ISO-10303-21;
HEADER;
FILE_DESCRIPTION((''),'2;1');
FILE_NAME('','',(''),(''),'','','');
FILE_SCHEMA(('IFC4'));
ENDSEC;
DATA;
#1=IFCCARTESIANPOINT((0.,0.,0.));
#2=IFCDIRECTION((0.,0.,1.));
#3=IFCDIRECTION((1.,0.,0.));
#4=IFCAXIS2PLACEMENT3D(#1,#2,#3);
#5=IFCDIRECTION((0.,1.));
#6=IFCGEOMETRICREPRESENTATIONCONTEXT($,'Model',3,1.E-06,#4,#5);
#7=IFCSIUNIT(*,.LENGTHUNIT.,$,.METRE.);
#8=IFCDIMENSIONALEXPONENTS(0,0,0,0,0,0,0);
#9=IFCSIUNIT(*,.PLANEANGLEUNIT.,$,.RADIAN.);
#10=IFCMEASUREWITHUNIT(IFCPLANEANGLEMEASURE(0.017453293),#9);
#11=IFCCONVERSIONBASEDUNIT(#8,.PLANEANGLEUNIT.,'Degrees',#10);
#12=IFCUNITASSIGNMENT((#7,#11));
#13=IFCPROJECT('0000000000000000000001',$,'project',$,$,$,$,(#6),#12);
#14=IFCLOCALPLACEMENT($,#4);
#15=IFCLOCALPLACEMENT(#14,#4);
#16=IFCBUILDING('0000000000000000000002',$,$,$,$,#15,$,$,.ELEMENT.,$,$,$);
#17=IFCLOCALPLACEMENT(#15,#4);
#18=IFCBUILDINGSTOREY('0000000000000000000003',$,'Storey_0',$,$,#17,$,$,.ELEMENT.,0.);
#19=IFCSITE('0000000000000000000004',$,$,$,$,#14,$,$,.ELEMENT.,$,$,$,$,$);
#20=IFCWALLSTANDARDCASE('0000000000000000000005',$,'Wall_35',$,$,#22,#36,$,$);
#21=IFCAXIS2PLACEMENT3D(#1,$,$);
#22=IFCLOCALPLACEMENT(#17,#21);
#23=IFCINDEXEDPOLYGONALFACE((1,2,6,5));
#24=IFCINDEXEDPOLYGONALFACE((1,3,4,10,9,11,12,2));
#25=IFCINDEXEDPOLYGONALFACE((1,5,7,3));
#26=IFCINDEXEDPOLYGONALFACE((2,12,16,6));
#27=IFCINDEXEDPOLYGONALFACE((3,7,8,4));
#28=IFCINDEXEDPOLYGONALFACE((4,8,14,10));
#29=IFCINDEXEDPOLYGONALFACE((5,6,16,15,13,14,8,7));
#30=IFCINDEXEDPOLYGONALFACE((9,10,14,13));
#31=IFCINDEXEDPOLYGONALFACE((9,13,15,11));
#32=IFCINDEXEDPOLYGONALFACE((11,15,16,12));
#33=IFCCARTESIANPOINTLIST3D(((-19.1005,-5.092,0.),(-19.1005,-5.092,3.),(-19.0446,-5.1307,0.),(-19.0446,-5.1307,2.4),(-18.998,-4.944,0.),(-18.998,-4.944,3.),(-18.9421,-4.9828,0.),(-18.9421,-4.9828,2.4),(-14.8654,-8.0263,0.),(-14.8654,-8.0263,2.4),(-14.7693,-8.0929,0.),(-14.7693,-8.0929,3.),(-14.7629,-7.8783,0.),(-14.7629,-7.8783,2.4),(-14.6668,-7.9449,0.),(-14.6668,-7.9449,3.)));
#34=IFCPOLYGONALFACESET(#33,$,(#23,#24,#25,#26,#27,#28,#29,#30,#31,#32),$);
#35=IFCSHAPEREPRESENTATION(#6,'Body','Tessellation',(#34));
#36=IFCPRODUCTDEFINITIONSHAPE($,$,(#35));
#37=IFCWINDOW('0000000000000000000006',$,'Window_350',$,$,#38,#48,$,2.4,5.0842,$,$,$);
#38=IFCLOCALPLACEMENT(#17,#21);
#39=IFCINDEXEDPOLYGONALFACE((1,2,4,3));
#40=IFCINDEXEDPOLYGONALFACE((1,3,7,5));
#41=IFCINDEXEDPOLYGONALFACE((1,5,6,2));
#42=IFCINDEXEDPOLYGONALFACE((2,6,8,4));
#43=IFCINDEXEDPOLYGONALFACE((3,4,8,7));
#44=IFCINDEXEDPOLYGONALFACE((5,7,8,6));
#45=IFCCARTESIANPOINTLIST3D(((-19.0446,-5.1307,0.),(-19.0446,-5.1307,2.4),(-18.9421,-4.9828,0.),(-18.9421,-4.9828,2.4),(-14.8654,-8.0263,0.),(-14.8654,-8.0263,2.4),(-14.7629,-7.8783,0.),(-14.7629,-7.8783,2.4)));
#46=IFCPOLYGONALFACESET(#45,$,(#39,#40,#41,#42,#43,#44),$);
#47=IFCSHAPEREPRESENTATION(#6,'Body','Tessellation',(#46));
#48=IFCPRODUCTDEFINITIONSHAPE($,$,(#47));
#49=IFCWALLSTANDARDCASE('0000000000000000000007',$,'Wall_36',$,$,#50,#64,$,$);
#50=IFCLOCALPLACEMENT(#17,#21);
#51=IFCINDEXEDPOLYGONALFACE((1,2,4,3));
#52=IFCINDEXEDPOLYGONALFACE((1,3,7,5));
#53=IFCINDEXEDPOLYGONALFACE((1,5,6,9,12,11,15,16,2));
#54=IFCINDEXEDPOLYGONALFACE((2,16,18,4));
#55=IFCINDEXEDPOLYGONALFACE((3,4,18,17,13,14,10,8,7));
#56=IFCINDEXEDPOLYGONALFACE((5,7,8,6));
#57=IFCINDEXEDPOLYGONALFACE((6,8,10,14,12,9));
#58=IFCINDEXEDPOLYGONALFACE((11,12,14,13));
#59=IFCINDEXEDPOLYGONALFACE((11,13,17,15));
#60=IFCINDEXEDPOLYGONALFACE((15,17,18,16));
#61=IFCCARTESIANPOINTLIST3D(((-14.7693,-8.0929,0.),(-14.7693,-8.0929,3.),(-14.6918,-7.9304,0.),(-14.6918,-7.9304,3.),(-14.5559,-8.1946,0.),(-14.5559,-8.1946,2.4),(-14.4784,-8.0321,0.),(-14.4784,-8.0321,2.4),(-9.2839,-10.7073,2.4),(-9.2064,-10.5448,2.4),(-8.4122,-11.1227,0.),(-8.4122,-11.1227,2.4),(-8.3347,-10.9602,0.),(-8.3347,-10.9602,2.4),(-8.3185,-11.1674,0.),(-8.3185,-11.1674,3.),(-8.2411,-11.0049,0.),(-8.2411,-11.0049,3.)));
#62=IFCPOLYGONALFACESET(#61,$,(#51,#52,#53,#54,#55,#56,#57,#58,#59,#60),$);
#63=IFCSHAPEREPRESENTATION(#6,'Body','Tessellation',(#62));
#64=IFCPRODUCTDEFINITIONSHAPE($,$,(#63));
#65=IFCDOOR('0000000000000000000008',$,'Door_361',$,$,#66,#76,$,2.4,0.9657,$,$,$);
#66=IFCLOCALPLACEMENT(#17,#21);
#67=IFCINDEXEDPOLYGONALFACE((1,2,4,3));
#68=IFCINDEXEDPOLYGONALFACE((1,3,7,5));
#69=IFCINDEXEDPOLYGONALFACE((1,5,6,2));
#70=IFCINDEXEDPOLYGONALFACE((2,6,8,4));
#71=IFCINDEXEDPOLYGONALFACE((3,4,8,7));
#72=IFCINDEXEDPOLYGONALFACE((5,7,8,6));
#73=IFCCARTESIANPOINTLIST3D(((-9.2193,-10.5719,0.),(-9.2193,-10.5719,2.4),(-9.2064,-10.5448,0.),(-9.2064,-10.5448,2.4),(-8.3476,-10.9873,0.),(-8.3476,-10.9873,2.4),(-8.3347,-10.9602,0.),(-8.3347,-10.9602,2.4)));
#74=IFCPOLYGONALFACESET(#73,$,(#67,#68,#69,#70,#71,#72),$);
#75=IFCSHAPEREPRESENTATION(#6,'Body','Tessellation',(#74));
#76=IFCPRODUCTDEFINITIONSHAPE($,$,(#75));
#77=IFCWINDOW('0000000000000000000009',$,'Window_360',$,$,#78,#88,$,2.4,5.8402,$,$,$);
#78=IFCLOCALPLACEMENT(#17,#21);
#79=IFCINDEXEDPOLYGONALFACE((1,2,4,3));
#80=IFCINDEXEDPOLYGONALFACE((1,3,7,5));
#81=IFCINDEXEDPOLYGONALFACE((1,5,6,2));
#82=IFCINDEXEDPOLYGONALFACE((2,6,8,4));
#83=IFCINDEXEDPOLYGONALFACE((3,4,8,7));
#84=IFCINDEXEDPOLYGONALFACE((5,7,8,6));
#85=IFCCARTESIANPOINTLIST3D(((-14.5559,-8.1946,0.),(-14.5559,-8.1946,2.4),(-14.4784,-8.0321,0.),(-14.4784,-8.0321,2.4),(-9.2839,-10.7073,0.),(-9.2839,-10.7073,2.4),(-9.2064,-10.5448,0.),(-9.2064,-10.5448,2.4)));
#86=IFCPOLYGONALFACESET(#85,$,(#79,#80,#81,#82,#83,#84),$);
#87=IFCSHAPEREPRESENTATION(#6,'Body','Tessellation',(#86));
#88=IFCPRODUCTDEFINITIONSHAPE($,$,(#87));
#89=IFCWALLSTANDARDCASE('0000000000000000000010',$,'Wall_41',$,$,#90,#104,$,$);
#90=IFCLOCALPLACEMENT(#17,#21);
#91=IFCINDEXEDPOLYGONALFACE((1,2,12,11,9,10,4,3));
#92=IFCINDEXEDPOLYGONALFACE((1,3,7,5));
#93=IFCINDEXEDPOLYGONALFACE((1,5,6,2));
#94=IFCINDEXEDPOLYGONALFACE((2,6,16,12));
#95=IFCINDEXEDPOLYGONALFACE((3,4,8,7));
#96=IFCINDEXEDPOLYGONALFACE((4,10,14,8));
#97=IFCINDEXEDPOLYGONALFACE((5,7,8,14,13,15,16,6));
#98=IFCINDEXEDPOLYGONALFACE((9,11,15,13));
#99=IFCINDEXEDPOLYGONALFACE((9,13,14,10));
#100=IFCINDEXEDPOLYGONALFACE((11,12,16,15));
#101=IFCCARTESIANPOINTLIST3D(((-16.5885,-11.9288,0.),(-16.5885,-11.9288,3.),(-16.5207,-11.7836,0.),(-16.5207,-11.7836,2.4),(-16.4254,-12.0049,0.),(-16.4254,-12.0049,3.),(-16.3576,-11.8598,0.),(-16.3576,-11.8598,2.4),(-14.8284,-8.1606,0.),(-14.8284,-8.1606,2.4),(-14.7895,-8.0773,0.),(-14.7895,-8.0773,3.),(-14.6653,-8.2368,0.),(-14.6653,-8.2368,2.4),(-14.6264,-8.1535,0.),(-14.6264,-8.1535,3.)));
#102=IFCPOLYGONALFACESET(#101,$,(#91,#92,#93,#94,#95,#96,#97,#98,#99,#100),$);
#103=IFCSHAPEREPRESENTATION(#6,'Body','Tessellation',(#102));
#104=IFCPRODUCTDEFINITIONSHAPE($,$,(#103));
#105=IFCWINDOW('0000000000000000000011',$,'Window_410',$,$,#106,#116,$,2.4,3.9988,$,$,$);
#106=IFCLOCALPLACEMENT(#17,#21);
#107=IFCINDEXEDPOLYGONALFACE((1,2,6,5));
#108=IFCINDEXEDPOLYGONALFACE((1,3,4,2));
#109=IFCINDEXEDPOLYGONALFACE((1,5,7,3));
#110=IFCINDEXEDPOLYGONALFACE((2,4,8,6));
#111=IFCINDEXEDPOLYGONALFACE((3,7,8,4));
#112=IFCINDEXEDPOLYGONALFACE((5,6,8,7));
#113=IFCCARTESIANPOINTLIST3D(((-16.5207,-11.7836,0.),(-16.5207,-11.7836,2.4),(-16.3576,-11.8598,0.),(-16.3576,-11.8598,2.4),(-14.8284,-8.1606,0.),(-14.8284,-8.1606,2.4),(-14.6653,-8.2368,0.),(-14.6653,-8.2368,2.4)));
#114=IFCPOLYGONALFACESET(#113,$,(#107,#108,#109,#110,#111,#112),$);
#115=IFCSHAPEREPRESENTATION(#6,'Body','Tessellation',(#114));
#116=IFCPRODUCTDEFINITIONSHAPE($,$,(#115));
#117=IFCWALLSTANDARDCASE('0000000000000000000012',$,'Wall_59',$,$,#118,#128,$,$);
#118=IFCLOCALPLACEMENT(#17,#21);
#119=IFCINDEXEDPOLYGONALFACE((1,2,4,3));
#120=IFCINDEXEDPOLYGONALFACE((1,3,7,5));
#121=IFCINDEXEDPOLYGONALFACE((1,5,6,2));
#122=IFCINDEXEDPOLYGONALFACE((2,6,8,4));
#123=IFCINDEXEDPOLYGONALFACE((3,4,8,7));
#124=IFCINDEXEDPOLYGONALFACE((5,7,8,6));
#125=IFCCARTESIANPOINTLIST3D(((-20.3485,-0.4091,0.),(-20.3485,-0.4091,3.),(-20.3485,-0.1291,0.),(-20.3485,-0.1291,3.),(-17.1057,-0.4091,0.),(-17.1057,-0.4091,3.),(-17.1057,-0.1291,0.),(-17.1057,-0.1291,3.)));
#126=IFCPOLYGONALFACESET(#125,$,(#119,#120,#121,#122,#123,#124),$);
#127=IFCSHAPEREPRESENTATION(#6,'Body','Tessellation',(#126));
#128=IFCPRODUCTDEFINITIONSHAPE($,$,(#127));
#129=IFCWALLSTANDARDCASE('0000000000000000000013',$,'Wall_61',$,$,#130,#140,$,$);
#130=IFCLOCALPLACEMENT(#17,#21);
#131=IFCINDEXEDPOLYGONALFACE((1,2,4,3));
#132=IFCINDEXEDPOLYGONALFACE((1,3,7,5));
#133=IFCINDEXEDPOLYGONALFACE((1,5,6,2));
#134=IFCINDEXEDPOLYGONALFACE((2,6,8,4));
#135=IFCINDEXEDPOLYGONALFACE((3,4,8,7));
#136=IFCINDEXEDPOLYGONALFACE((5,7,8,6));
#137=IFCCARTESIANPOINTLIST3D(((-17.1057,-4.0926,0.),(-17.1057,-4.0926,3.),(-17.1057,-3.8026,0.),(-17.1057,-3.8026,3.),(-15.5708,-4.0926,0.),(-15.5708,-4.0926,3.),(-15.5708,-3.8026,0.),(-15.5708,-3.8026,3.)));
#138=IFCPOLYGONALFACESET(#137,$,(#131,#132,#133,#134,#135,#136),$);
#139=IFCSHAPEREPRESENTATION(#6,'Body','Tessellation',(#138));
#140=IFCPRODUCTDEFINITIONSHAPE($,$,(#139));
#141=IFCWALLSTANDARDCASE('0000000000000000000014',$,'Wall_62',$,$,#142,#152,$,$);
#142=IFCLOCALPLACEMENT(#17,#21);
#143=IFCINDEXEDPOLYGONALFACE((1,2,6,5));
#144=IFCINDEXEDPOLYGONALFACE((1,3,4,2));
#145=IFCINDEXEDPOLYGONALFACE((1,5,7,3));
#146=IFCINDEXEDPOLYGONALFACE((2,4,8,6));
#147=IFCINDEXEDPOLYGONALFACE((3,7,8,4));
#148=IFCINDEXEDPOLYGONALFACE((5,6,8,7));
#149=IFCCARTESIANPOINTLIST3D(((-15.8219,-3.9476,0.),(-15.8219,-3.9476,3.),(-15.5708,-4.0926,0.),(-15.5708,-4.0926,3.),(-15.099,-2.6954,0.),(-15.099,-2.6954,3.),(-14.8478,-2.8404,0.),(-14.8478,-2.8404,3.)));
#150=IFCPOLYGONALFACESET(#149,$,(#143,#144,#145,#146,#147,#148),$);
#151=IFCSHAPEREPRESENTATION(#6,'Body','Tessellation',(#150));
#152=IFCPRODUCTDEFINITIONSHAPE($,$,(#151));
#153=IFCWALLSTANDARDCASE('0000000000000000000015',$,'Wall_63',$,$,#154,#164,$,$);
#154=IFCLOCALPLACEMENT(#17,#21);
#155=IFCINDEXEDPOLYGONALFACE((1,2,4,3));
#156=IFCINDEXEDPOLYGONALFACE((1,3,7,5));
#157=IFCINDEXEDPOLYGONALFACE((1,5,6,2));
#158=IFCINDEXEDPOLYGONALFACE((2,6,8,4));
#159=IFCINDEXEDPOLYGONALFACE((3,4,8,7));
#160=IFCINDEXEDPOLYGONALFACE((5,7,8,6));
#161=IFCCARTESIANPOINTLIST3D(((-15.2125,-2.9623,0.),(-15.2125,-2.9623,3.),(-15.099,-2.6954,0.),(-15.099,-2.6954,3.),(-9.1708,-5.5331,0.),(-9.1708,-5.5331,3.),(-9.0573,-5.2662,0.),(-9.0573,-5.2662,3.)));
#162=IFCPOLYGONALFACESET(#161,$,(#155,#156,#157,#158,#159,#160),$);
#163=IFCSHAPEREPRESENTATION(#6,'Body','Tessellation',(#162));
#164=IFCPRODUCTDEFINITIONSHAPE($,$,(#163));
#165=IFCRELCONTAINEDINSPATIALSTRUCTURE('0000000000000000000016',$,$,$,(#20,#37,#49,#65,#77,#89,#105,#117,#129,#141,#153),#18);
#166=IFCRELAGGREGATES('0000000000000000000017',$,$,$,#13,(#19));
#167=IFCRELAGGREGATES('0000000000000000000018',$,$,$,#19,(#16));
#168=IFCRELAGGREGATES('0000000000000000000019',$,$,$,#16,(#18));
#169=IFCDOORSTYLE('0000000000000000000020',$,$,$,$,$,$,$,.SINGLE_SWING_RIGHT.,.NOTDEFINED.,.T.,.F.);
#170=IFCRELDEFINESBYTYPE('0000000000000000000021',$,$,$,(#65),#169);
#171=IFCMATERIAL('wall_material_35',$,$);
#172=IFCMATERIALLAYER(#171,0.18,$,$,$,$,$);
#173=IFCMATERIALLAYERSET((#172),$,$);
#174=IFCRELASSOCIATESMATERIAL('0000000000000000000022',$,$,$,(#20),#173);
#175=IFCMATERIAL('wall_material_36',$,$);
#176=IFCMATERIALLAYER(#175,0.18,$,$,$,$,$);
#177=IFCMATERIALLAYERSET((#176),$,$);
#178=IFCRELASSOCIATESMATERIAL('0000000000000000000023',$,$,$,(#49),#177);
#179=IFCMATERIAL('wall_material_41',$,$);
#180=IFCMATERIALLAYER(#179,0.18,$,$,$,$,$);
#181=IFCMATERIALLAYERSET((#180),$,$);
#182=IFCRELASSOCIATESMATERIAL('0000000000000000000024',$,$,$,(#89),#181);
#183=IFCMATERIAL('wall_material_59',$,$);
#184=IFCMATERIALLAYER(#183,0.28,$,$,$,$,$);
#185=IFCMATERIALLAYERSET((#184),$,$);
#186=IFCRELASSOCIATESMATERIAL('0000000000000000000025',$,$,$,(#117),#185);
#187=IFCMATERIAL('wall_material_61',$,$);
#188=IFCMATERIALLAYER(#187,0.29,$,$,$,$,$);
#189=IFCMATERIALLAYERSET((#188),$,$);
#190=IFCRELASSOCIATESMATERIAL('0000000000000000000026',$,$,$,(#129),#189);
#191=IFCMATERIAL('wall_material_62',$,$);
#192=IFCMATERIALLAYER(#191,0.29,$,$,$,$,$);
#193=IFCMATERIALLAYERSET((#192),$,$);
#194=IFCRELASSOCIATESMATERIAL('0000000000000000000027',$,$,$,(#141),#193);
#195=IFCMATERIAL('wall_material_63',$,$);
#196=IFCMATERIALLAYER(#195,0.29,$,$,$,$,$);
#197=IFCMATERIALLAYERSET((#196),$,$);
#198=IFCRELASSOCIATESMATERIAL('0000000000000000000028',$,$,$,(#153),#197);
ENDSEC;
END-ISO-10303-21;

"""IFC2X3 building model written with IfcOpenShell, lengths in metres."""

from ifc_helpers import new_model, entity, si_unit, converted_unit, direction, frame, frame_2d, origin_with_axes, place, context, project, spatial, polyline, rectangle, outline, extrude, material, layer, layer_set, layer_usage, type_object, element, fill, save


model = new_model("IFC2X3")

# Units and contexts
model_context = context("Model", 3, precision=1e-06, world=origin_with_axes(), true_north=direction((0.0, 1.0)))
ifc_project = project(units=[si_unit("LENGTHUNIT", "METRE"), converted_unit("PLANEANGLEUNIT", "Degrees", entity("IfcPlaneAngleMeasure", 0.017453293), si_unit("PLANEANGLEUNIT", "RADIAN"), dimensions=[0, 0, 0, 0, 0, 0, 0])], contexts=[model_context])

# Site, building, storey
site_placement = place(None, origin_with_axes())
site = spatial("IfcSite", under=ifc_project, at=site_placement, CompositionType="ELEMENT")
building_placement = place(site_placement, origin_with_axes())
building = spatial("IfcBuilding", under=site, at=building_placement, CompositionType="ELEMENT")
storey_placement = place(building_placement, origin_with_axes())
storey = spatial("IfcBuildingStorey", under=building, at=storey_placement, Name="Storey_0", CompositionType="ELEMENT", Elevation=0.0)

# Wall, opening, window
ifc_material_1 = material(Name="wall_material_35")
ifc_layer_1 = layer(ifc_material_1, 0.18)
ifc_layer_set_1 = layer_set([ifc_layer_1])
ifc_layer_usage_1 = layer_usage(ifc_layer_set_1, "AXIS2", "NEGATIVE", 0.0)
wall_1_placement = place(storey_placement, frame((-18.998, -4.944, 0.0), z_axis=(0.0, 0.0, 1.0), x_axis=(0.821979, -0.569518, 0.0)))
wall_1 = element("IfcWallStandardCase", 1, at=wall_1_placement, inside=storey, material=ifc_layer_usage_1, Name="Wall_35", context=model_context, shape_type="SweptSolid", body=[
    extrude(outline(polyline([(0.0, 0.0), (5.2692, 0.0), (5.2692, -0.18), (0.0, -0.18), (0.0, 0.0)])), origin_with_axes(), (0.0, 0.0, 1.0), 3.0),
])
opening_1_placement = place(wall_1_placement, frame((0.068, 0.0, 0.0), z_axis=(0.0, 0.0, 1.0), x_axis=(1.0, 0.0, 0.0)))
opening_1 = element("IfcOpeningElement", 2, at=opening_1_placement, cuts=wall_1, context=model_context, shape_type="SweptSolid", body=[
    extrude(rectangle(XDim=5.0842, YDim=2.4, at=frame_2d((1.2, -2.5421), x_axis=(0.0, 1.0))), frame((0.0, 0.01, 0.0), z_axis=(0.0, -1.0, 0.0), x_axis=(0.0, 0.0, 1.0)), (0.0, 0.0, 1.0), 0.2),
])
window_1_placement = place(storey_placement, origin_with_axes())
window_1 = element("IfcWindow", 3, at=window_1_placement, inside=storey, Name="Window_350", OverallHeight=2.4, OverallWidth=5.0842, context=model_context, shape_type="SweptSolid", body=[
    extrude(outline(polyline([(-18.9421, -4.9828), (-14.7629, -7.8783), (-14.8654, -8.0263), (-19.0446, -5.1307), (-18.9421, -4.9828)])), origin_with_axes(), (0.0, 0.0, 1.0), 2.4),
])
fill(opening_1, window_1)

# Wall, openings, door, window
ifc_material_2 = material(Name="wall_material_36")
ifc_layer_2 = layer(ifc_material_2, 0.18)
ifc_layer_set_2 = layer_set([ifc_layer_2])
ifc_layer_usage_2 = layer_usage(ifc_layer_set_2, "AXIS2", "NEGATIVE", 0.0)
wall_2_placement = place(storey_placement, frame((-14.6918, -7.9304, 0.0), z_axis=(0.0, 0.0, 1.0), x_axis=(0.902716, -0.430236, 0.0)))
wall_2 = element("IfcWallStandardCase", 4, at=wall_2_placement, inside=storey, material=ifc_layer_usage_2, Name="Wall_36", context=model_context, shape_type="SweptSolid", body=[
    extrude(outline(polyline([(0.0, 0.0), (7.146, 0.0), (7.146, -0.18), (0.0, -0.18), (0.0, 0.0)])), origin_with_axes(), (0.0, 0.0, 1.0), 3.0),
])
opening_2_placement = place(wall_2_placement, frame((0.2364, 0.0, 0.0), z_axis=(0.0, 0.0, 1.0), x_axis=(1.0, 0.0, 0.0)))
opening_2 = element("IfcOpeningElement", 5, at=opening_2_placement, cuts=wall_2, context=model_context, shape_type="SweptSolid", body=[
    extrude(rectangle(XDim=5.8402, YDim=2.4, at=frame_2d((1.2, -2.9201), x_axis=(0.0, 1.0))), frame((0.0, 0.01, 0.0), z_axis=(0.0, -1.0, 0.0), x_axis=(0.0, 0.0, 1.0)), (0.0, 0.0, 1.0), 0.2),
])
opening_3_placement = place(wall_2_placement, frame((6.0766, 0.0, 0.0), z_axis=(0.0, 0.0, 1.0), x_axis=(1.0, 0.0, 0.0)))
opening_3 = element("IfcOpeningElement", 6, at=opening_3_placement, cuts=wall_2, context=model_context, shape_type="SweptSolid", body=[
    extrude(rectangle(XDim=0.9657, YDim=2.4, at=frame_2d((1.2, -0.4828), x_axis=(0.0, 1.0))), frame((0.0, 0.01, 0.0), z_axis=(0.0, -1.0, 0.0), x_axis=(0.0, 0.0, 1.0)), (0.0, 0.0, 1.0), 0.2),
])
door_style_1 = type_object("IfcDoorStyle", ConstructionType="NOTDEFINED", OperationType="SINGLE_SWING_RIGHT", ParameterTakesPrecedence=True, Sizeable=False)
door_1_placement = place(storey_placement, origin_with_axes())
door_1 = element("IfcDoor", 7, at=door_1_placement, inside=storey, type_object=door_style_1, Name="Door_361", OverallHeight=2.4, OverallWidth=0.9657, context=model_context, shape_type="SweptSolid", body=[
    extrude(outline(polyline([(-9.2064, -10.5448), (-8.3347, -10.9602), (-8.3476, -10.9873), (-9.2193, -10.5719), (-9.2064, -10.5448)])), origin_with_axes(), (0.0, 0.0, 1.0), 2.4),
])
fill(opening_3, door_1)
window_2_placement = place(storey_placement, origin_with_axes())
window_2 = element("IfcWindow", 8, at=window_2_placement, inside=storey, Name="Window_360", OverallHeight=2.4, OverallWidth=5.8402, context=model_context, shape_type="SweptSolid", body=[
    extrude(outline(polyline([(-14.4784, -8.0321), (-9.2064, -10.5448), (-9.2839, -10.7073), (-14.5559, -8.1946), (-14.4784, -8.0321)])), origin_with_axes(), (0.0, 0.0, 1.0), 2.4),
])
fill(opening_2, window_2)

# Wall, opening, window
ifc_material_3 = material(Name="wall_material_41")
ifc_layer_3 = layer(ifc_material_3, 0.18)
ifc_layer_set_3 = layer_set([ifc_layer_3])
ifc_layer_usage_3 = layer_usage(ifc_layer_set_3, "AXIS2", "NEGATIVE", 0.0)
wall_3_placement = place(storey_placement, frame((-16.5885, -11.9288, 0.0), z_axis=(0.0, 0.0, 1.0), x_axis=(0.423217, 0.906028, 0.0)))
wall_3 = element("IfcWallStandardCase", 9, at=wall_3_placement, inside=storey, material=ifc_layer_usage_3, Name="Wall_41", context=model_context, shape_type="SweptSolid", body=[
    extrude(outline(polyline([(0.0, 0.0), (4.2509, 0.0), (4.2509, -0.18), (0.0, -0.18), (0.0, 0.0)])), origin_with_axes(), (0.0, 0.0, 1.0), 3.0),
])
opening_4_placement = place(wall_3_placement, frame((0.1602, 0.0, 0.0), z_axis=(0.0, 0.0, 1.0), x_axis=(1.0, 0.0, 0.0)))
opening_4 = element("IfcOpeningElement", 10, at=opening_4_placement, cuts=wall_3, context=model_context, shape_type="SweptSolid", body=[
    extrude(rectangle(XDim=3.9988, YDim=2.4, at=frame_2d((1.2, -1.9994), x_axis=(0.0, 1.0))), frame((0.0, 0.01, 0.0), z_axis=(0.0, -1.0, 0.0), x_axis=(0.0, 0.0, 1.0)), (0.0, 0.0, 1.0), 0.2),
])
window_3_placement = place(storey_placement, origin_with_axes())
window_3 = element("IfcWindow", 11, at=window_3_placement, inside=storey, Name="Window_410", OverallHeight=2.4, OverallWidth=3.9988, context=model_context, shape_type="SweptSolid", body=[
    extrude(outline(polyline([(-16.5207, -11.7836), (-14.8284, -8.1606), (-14.6653, -8.2368), (-16.3576, -11.8598), (-16.5207, -11.7836)])), origin_with_axes(), (0.0, 0.0, 1.0), 2.4),
])
fill(opening_4, window_3)

# Walls
ifc_material_4 = material(Name="wall_material_59")
ifc_layer_4 = layer(ifc_material_4, 0.28)
ifc_layer_set_4 = layer_set([ifc_layer_4])
ifc_layer_usage_4 = layer_usage(ifc_layer_set_4, "AXIS2", "POSITIVE", 0.0)
wall_4_placement = place(storey_placement, frame((-20.3485, -0.4091, 0.0), z_axis=(0.0, 0.0, 1.0), x_axis=(1.0, 0.0, 0.0)))
element("IfcWallStandardCase", 12, at=wall_4_placement, inside=storey, material=ifc_layer_usage_4, Name="Wall_59", context=model_context, shape_type="SweptSolid", body=[
    extrude(outline(polyline([(0.0, 0.28), (3.2428, 0.28), (3.2428, 0.0), (0.0, 0.0), (0.0, 0.28)])), origin_with_axes(), (0.0, 0.0, 1.0), 3.0),
])
ifc_material_5 = material(Name="wall_material_61")
ifc_layer_5 = layer(ifc_material_5, 0.29)
ifc_layer_set_5 = layer_set([ifc_layer_5])
ifc_layer_usage_5 = layer_usage(ifc_layer_set_5, "AXIS2", "POSITIVE", 0.0)
wall_5_placement = place(storey_placement, frame((-17.1057, -4.0926, 0.0), z_axis=(0.0, 0.0, 1.0), x_axis=(1.0, 0.0, 0.0)))
element("IfcWallStandardCase", 13, at=wall_5_placement, inside=storey, material=ifc_layer_usage_5, Name="Wall_61", context=model_context, shape_type="SweptSolid", body=[
    extrude(outline(polyline([(0.0, 0.29), (1.5349, 0.29), (1.5349, 0.0), (0.0, 0.0), (0.0, 0.29)])), origin_with_axes(), (0.0, 0.0, 1.0), 3.0),
])
ifc_material_6 = material(Name="wall_material_62")
ifc_layer_6 = layer(ifc_material_6, 0.29)
ifc_layer_set_6 = layer_set([ifc_layer_6])
ifc_layer_usage_6 = layer_usage(ifc_layer_set_6, "AXIS2", "POSITIVE", 0.0)
wall_6_placement = place(storey_placement, frame((-15.5708, -4.0926, 0.0), z_axis=(0.0, 0.0, 1.0), x_axis=(0.500006, 0.866022, 0.0)))
element("IfcWallStandardCase", 14, at=wall_6_placement, inside=storey, material=ifc_layer_usage_6, Name="Wall_62", context=model_context, shape_type="SweptSolid", body=[
    extrude(outline(polyline([(0.0, 0.29), (1.4459, 0.29), (1.4459, 0.0), (0.0, 0.0), (0.0, 0.29)])), origin_with_axes(), (0.0, 0.0, 1.0), 3.0),
])
ifc_material_7 = material(Name="wall_material_63")
ifc_layer_7 = layer(ifc_material_7, 0.29)
ifc_layer_set_7 = layer_set([ifc_layer_7])
ifc_layer_usage_7 = layer_usage(ifc_layer_set_7, "AXIS2", "NEGATIVE", 0.0)
wall_7_placement = place(storey_placement, frame((-15.099, -2.6954, 0.0), z_axis=(0.0, 0.0, 1.0), x_axis=(0.920164, -0.391534, 0.0)))
element("IfcWallStandardCase", 15, at=wall_7_placement, inside=storey, material=ifc_layer_usage_7, Name="Wall_63", context=model_context, shape_type="SweptSolid", body=[
    extrude(outline(polyline([(0.0, 0.0), (6.5659, 0.0), (6.5659, -0.29), (0.0, -0.29), (0.0, 0.0)])), origin_with_axes(), (0.0, 0.0, 1.0), 3.0),
])

save(model, "model.ifc")
